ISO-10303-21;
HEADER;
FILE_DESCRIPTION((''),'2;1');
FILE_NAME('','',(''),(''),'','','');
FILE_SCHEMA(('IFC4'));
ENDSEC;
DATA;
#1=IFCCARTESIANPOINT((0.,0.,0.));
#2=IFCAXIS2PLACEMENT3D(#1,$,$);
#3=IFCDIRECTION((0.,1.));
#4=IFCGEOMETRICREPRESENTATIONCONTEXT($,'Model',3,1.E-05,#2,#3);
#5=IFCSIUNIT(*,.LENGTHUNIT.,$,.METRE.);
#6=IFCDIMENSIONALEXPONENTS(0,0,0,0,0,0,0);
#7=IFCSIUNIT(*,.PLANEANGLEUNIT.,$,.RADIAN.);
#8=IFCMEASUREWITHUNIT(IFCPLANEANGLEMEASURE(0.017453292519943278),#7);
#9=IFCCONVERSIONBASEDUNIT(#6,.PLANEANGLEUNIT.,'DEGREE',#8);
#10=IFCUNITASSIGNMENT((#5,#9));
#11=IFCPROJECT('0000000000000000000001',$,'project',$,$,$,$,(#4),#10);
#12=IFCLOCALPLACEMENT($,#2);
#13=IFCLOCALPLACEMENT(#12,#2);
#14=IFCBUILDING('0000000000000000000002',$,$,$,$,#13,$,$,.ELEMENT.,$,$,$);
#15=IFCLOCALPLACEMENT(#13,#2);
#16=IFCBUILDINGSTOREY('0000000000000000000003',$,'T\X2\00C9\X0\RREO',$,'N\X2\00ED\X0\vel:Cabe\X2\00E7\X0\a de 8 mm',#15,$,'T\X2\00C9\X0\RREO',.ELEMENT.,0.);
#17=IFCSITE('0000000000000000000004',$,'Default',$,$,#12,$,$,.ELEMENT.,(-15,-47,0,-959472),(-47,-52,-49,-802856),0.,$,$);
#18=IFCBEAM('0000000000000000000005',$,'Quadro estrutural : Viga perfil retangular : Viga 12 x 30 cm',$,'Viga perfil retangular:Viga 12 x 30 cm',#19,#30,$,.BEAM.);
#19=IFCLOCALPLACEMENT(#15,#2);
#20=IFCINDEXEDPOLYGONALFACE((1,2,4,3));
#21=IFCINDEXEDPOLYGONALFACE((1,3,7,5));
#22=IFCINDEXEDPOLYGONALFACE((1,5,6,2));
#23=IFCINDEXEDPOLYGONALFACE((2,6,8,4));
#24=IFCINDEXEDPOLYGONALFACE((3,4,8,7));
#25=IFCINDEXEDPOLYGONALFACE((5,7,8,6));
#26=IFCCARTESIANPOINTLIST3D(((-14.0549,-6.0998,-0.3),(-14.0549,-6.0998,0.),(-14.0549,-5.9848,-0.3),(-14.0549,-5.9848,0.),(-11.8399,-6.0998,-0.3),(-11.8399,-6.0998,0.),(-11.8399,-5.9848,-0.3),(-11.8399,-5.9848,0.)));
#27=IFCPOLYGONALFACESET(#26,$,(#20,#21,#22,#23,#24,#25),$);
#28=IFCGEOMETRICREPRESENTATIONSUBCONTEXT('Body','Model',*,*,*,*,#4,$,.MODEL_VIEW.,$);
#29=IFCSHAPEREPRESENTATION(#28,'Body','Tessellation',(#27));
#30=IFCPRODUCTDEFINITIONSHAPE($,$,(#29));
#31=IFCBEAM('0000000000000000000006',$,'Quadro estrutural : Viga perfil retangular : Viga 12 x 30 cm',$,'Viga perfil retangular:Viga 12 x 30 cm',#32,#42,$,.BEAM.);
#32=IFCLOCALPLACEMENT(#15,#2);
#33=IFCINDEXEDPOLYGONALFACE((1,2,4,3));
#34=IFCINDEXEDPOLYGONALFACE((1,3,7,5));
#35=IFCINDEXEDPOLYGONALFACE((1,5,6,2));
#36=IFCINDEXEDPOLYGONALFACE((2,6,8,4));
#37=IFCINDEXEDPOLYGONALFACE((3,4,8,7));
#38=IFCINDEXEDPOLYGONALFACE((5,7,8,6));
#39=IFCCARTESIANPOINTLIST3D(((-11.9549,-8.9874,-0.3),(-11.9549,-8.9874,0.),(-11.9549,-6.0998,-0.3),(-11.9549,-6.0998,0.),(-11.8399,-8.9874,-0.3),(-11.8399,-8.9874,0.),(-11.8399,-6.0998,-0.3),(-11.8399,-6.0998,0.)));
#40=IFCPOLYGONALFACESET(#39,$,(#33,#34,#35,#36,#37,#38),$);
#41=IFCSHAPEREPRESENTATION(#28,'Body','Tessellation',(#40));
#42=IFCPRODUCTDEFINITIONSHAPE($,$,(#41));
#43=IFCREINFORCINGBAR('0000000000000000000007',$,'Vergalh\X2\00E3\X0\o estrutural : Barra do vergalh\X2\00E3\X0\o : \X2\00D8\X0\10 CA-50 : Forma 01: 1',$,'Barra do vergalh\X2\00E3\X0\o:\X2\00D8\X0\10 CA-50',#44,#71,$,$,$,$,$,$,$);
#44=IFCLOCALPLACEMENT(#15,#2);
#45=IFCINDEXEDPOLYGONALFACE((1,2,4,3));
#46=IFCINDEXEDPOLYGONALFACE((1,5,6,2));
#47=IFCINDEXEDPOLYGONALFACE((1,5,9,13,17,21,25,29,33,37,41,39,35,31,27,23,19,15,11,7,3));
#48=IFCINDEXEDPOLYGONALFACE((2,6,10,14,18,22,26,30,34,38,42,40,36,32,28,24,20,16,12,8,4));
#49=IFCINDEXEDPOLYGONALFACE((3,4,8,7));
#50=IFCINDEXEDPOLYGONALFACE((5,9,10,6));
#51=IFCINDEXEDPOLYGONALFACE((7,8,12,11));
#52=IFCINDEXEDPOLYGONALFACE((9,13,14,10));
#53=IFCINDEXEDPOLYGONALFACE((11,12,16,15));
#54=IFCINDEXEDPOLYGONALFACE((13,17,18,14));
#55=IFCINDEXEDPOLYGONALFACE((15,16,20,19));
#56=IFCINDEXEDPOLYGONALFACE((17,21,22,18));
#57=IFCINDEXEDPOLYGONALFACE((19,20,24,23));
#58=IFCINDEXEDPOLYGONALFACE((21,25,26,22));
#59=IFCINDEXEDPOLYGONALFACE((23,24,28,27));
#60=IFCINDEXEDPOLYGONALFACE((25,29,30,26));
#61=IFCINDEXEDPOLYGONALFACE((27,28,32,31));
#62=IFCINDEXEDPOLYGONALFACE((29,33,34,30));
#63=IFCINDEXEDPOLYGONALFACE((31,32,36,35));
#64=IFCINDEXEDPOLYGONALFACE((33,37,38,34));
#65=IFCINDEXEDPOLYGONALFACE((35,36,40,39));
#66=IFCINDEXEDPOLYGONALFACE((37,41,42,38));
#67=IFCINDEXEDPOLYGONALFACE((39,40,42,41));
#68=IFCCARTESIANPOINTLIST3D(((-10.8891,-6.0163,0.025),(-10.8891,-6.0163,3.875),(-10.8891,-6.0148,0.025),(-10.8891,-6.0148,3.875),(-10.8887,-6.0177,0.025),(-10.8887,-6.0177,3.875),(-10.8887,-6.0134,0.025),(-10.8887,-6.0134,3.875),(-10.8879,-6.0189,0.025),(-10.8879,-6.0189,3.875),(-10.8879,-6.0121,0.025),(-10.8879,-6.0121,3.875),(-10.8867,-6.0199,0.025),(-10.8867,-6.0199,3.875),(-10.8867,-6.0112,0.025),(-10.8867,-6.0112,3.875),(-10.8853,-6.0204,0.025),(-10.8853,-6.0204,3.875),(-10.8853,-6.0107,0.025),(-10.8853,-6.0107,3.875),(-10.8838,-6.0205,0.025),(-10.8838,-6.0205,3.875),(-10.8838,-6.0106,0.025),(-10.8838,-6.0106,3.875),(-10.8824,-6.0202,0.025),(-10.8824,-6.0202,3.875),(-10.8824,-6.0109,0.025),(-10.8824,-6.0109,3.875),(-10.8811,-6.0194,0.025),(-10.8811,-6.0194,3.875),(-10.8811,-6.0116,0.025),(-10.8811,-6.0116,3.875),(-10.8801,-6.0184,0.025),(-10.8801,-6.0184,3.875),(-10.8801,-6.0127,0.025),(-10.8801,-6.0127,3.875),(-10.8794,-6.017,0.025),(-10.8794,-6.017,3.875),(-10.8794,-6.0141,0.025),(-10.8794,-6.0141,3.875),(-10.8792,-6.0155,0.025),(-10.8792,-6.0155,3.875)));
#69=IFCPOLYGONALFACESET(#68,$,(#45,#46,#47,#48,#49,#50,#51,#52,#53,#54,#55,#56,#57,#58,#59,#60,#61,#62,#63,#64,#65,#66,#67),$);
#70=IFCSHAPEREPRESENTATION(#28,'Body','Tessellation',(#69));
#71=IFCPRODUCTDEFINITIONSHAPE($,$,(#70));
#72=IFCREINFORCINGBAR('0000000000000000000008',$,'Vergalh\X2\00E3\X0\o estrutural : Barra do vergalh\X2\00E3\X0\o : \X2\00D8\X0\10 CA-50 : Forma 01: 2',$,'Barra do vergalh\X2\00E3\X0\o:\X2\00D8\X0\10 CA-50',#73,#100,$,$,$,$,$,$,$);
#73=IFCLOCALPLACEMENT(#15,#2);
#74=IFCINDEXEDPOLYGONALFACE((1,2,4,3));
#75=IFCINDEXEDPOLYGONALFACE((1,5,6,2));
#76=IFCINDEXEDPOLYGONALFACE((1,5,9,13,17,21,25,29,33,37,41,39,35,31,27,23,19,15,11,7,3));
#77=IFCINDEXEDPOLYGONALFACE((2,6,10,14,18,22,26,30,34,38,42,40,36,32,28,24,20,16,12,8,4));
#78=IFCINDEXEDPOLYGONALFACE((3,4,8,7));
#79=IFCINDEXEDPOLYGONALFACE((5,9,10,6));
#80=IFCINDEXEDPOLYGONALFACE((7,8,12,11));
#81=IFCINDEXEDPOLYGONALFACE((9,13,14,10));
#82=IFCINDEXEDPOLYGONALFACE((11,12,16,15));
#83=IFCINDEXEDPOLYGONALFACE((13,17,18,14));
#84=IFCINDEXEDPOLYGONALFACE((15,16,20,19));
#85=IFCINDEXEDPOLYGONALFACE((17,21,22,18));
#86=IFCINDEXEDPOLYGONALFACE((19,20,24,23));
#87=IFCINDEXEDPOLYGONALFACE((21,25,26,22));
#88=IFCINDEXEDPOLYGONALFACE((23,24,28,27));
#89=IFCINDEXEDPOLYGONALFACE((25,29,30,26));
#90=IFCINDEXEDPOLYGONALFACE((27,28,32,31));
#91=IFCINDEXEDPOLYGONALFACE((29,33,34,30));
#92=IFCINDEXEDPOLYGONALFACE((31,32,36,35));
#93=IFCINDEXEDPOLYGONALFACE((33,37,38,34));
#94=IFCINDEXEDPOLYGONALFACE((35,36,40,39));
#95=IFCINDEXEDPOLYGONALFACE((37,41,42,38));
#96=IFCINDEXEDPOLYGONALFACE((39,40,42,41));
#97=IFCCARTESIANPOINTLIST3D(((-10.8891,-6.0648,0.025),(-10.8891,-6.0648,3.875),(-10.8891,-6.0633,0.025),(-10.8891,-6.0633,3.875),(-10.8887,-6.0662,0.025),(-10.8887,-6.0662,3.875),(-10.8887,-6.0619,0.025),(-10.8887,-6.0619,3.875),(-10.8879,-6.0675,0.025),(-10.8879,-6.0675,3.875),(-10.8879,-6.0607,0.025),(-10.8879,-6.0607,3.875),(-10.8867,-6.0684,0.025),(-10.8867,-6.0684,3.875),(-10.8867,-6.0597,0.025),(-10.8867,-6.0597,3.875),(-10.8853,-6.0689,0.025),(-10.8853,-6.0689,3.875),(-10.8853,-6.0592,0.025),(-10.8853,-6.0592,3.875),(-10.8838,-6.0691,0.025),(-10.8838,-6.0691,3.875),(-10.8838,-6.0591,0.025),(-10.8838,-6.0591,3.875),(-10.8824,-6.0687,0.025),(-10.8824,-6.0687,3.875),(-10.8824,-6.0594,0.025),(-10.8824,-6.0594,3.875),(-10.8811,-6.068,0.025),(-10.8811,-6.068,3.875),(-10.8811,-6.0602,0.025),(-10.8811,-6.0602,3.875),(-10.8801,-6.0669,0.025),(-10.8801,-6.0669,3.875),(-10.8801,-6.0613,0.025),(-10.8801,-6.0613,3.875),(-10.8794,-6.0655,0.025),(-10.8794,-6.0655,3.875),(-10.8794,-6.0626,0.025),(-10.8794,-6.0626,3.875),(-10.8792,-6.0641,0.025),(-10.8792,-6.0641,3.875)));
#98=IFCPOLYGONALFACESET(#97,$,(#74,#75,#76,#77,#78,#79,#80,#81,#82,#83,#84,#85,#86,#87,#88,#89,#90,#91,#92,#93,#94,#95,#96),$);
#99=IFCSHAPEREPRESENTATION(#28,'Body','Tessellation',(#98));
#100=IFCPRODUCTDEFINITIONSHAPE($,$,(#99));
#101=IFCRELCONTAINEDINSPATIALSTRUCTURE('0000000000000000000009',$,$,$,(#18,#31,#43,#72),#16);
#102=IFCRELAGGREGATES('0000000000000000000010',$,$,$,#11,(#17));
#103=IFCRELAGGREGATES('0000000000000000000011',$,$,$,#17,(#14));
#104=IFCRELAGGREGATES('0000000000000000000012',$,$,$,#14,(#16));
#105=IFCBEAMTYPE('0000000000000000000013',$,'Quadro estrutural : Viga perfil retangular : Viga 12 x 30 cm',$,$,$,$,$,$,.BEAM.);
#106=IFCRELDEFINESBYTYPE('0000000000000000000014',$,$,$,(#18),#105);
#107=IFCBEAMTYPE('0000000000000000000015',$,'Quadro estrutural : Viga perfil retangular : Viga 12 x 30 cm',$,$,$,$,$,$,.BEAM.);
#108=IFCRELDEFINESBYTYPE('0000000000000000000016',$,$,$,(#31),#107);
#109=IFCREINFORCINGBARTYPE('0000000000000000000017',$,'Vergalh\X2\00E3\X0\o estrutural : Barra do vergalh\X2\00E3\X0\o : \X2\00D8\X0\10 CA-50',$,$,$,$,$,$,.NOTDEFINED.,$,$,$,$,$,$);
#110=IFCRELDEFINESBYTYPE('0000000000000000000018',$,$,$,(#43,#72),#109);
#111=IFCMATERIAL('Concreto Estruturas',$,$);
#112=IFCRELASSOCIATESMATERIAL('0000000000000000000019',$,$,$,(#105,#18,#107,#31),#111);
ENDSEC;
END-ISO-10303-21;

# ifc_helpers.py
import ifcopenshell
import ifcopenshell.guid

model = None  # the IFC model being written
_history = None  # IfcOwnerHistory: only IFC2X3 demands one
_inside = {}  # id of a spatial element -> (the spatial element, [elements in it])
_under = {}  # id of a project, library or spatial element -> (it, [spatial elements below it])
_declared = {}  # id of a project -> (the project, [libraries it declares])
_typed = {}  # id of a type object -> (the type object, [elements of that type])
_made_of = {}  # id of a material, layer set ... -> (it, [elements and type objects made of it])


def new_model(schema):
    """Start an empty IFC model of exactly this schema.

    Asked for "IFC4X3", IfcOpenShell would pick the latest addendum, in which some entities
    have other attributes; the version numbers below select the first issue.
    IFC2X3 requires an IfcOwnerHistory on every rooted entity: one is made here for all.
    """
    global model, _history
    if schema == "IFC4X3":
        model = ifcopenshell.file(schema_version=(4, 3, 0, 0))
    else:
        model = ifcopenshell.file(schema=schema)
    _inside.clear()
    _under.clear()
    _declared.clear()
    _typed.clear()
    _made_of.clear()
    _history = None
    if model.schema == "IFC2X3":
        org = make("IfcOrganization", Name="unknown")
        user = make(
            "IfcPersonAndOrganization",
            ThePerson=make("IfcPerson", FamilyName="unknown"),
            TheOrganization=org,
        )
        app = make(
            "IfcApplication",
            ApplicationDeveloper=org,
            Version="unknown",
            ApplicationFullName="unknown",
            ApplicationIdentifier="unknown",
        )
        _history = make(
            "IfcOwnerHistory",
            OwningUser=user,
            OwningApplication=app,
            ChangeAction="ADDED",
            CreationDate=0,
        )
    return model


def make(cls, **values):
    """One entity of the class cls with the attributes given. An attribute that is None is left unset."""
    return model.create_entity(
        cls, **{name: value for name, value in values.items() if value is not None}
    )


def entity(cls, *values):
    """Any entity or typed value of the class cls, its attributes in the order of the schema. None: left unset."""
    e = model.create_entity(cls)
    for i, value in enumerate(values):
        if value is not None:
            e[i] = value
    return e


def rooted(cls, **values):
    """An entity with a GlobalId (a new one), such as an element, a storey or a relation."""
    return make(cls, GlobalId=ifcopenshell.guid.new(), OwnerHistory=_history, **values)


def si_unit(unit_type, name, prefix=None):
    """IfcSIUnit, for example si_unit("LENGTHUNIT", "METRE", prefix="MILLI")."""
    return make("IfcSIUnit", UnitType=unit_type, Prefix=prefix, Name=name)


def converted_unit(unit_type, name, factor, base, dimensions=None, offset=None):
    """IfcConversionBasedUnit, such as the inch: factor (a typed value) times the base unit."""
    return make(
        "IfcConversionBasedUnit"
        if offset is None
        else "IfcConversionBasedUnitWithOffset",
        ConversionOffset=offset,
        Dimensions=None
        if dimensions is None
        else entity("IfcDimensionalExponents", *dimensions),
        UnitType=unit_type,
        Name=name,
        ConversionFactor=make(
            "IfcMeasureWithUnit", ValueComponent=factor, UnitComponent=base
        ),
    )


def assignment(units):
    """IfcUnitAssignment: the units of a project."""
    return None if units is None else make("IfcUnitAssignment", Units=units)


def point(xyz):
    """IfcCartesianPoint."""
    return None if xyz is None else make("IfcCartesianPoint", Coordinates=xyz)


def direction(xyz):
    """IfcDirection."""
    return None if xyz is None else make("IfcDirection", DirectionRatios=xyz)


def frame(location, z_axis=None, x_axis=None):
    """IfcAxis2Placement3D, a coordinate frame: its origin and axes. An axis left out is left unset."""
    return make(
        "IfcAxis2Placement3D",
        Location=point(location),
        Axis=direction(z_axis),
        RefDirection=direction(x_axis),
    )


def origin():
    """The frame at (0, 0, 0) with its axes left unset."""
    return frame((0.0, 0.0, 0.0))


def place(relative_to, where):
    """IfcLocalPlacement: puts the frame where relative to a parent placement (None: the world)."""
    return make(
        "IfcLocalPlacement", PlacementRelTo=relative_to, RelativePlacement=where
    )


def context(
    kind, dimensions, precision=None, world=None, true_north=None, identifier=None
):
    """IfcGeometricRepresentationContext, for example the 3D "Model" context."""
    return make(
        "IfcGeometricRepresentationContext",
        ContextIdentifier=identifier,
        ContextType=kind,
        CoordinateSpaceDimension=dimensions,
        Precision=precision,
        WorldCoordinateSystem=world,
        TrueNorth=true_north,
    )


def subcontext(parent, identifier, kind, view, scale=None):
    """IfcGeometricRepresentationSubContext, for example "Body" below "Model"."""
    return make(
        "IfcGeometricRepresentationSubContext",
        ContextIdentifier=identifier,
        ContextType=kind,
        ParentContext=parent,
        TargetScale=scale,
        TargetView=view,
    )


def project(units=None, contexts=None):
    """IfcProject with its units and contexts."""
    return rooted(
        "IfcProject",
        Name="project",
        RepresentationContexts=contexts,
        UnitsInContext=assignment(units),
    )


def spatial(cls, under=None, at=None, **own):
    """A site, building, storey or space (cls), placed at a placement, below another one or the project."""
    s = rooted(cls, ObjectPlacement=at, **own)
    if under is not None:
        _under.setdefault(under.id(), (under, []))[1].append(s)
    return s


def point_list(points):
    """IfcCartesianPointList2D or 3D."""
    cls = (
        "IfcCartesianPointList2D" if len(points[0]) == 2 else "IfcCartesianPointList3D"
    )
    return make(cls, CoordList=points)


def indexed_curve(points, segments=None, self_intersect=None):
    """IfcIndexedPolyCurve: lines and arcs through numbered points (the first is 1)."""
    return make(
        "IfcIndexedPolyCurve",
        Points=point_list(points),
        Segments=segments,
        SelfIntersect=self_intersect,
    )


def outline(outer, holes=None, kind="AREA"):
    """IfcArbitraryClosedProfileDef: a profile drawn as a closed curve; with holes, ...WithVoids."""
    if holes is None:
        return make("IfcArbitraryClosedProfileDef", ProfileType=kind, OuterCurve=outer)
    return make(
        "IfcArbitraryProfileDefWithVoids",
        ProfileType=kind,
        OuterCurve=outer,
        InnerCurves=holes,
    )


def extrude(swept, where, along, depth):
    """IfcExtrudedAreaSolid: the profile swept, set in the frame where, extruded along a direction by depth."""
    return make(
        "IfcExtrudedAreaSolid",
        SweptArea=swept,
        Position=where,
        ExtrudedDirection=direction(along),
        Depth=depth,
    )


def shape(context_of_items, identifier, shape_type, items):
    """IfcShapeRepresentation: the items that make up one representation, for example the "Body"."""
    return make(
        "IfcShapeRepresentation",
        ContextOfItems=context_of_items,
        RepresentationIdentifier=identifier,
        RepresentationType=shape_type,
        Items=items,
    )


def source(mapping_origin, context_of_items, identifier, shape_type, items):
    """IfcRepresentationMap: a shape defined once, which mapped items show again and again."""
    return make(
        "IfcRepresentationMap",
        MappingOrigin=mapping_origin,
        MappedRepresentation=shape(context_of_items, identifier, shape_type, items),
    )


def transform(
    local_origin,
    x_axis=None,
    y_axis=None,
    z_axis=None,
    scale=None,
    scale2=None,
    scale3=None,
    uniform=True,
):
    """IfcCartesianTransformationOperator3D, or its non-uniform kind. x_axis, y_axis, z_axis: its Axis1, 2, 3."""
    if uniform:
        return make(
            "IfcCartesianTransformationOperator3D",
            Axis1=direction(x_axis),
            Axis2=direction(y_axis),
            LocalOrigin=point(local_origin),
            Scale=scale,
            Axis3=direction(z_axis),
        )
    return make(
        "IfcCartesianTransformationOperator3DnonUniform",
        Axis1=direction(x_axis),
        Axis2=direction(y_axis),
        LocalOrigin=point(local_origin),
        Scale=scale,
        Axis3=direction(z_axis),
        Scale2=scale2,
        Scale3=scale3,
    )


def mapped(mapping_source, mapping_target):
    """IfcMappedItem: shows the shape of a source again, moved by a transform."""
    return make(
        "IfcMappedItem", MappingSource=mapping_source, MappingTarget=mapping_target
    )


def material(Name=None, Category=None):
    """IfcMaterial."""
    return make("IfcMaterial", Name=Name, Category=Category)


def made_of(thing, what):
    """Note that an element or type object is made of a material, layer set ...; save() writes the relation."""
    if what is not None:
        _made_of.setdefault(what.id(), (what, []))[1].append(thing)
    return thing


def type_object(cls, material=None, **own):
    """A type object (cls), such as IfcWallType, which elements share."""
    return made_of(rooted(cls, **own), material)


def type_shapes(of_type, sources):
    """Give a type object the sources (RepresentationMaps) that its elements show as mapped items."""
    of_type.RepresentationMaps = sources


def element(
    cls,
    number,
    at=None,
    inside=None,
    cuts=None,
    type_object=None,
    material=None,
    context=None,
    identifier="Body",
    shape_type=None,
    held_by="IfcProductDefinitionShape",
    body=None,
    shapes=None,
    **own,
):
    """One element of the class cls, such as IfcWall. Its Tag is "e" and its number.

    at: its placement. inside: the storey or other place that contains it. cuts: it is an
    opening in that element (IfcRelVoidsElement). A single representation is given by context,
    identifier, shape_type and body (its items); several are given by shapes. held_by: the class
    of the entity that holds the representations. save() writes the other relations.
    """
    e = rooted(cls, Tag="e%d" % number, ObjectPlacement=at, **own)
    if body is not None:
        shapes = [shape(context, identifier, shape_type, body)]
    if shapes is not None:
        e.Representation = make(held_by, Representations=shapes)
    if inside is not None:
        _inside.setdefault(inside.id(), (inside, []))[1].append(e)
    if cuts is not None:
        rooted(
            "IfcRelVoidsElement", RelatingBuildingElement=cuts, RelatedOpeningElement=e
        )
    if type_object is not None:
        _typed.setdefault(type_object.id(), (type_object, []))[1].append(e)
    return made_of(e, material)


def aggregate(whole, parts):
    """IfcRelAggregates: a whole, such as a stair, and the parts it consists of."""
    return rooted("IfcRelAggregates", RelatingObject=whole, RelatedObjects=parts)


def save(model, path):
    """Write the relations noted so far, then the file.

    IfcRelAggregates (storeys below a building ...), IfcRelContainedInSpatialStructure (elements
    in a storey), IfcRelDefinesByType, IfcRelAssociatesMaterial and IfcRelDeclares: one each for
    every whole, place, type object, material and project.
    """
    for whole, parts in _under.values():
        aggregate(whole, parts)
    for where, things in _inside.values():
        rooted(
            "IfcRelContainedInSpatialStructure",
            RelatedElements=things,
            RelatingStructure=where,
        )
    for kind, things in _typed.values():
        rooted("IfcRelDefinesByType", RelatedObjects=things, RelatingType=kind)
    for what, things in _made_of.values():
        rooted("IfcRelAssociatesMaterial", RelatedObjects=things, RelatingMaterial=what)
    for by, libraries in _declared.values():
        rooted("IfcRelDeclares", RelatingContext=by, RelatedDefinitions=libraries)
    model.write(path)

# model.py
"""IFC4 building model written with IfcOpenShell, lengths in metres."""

from ifc_helpers import new_model, entity, si_unit, converted_unit, direction, frame, origin, place, context, subcontext, project, spatial, indexed_curve, outline, extrude, source, transform, mapped, material, type_object, type_shapes, element, save


model = new_model("IFC4")

# Units and contexts
model_context = context("Model", 3, precision=1e-05, world=origin(), true_north=direction((0.0, 1.0)))
body_context = subcontext(model_context, "Body", "Model", "MODEL_VIEW")
ifc_project = project(units=[si_unit("LENGTHUNIT", "METRE"), converted_unit("PLANEANGLEUNIT", "DEGREE", entity("IfcPlaneAngleMeasure", 0.017453292519943278), si_unit("PLANEANGLEUNIT", "RADIAN"), dimensions=[0, 0, 0, 0, 0, 0, 0])], contexts=[model_context])

# Site, building, storey
site_placement = place(None, origin())
site = spatial("IfcSite", under=ifc_project, at=site_placement, Name="Default", CompositionType="ELEMENT", RefLatitude=(-15, -47, 0, -959472), RefLongitude=(-47, -52, -49, -802856), RefElevation=0.0)
building_placement = place(site_placement, origin())
building = spatial("IfcBuilding", under=site, at=building_placement, CompositionType="ELEMENT")
storey_placement = place(building_placement, origin())
storey = spatial("IfcBuildingStorey", under=building, at=storey_placement, Name="TÉRREO", ObjectType="Nível:Cabeça de 8 mm", LongName="TÉRREO", CompositionType="ELEMENT", Elevation=0.0)

# Beams
ifc_material = material(Name="Concreto Estruturas")
beam_type_1 = type_object("IfcBeamType", Name="Quadro estrutural : Viga perfil retangular : Viga 12 x 30 cm", PredefinedType="BEAM", material=ifc_material)
shared_shape_1 = source(origin(), body_context, "Body", "SweptSolid", [
    extrude(outline(indexed_curve([(-0.15, -0.0575), (0.15, -0.0575), (0.15, 0.0575), (-0.15, 0.0575), (-0.15, -0.0575)], self_intersect=False)), frame((-14.0549, -6.0423, -0.15), z_axis=(1.0, 0.0, 0.0), x_axis=(0.0, 0.0, -1.0)), (0.0, 0.0, 1.0), 2.215),
])
type_shapes(beam_type_1, [shared_shape_1])
beam_1_placement = place(storey_placement, origin())
element("IfcBeam", 1, at=beam_1_placement, inside=storey, type_object=beam_type_1, material=ifc_material, Name="Quadro estrutural : Viga perfil retangular : Viga 12 x 30 cm", ObjectType="Viga perfil retangular:Viga 12 x 30 cm", PredefinedType="BEAM", context=body_context, shape_type="MappedRepresentation", body=[
    mapped(shared_shape_1, transform((0.0, 0.0, 0.0), scale=1.0)),
])
beam_type_2 = type_object("IfcBeamType", Name="Quadro estrutural : Viga perfil retangular : Viga 12 x 30 cm", PredefinedType="BEAM", material=ifc_material)
shared_shape_2 = source(origin(), body_context, "Body", "SweptSolid", [
    extrude(outline(indexed_curve([(-0.0575, -0.15), (0.0575, -0.15), (0.0575, 0.15), (-0.0575, 0.15), (-0.0575, -0.15)], self_intersect=False)), frame((-11.8974, -6.0998, -0.15), z_axis=(0.0, -1.0, 0.0), x_axis=(-1.0, 0.0, 0.0)), (0.0, 0.0, 1.0), 2.8876),
])
type_shapes(beam_type_2, [shared_shape_2])
beam_2_placement = place(storey_placement, origin())
element("IfcBeam", 2, at=beam_2_placement, inside=storey, type_object=beam_type_2, material=ifc_material, Name="Quadro estrutural : Viga perfil retangular : Viga 12 x 30 cm", ObjectType="Viga perfil retangular:Viga 12 x 30 cm", PredefinedType="BEAM", context=body_context, shape_type="MappedRepresentation", body=[
    mapped(shared_shape_2, transform((0.0, 0.0, 0.0), scale=1.0)),
])

# Reinforcing bars
reinforcing_bar_type_1 = type_object("IfcReinforcingBarType", Name="Vergalhão estrutural : Barra do vergalhão : Ø10 CA-50", PredefinedType="NOTDEFINED")
reinforcing_bar_1_placement = place(storey_placement, origin())
element("IfcReinforcingBar", 3, at=reinforcing_bar_1_placement, inside=storey, type_object=reinforcing_bar_type_1, Name="Vergalhão estrutural : Barra do vergalhão : Ø10 CA-50 : Forma 01: 1", ObjectType="Barra do vergalhão:Ø10 CA-50", context=body_context, shape_type="AdvancedSweptSolid", body=[
    entity("IfcSweptDiskSolid", entity("IfcIndexedPolyCurve", entity("IfcCartesianPointList3D", [[-10.8842, -6.0155, 0.025], [-10.8842, -6.0155, 3.875]]), None, False), 0.005, None, 0.0, 1.0),
])
reinforcing_bar_2_placement = place(storey_placement, origin())
element("IfcReinforcingBar", 4, at=reinforcing_bar_2_placement, inside=storey, type_object=reinforcing_bar_type_1, Name="Vergalhão estrutural : Barra do vergalhão : Ø10 CA-50 : Forma 01: 2", ObjectType="Barra do vergalhão:Ø10 CA-50", context=body_context, shape_type="AdvancedSweptSolid", body=[
    entity("IfcSweptDiskSolid", entity("IfcIndexedPolyCurve", entity("IfcCartesianPointList3D", [[-10.8842, -6.0641, 0.025], [-10.8842, -6.0641, 3.875]]), None, False), 0.005, None, 0.0, 1.0),
])

save(model, "model.ifc")
